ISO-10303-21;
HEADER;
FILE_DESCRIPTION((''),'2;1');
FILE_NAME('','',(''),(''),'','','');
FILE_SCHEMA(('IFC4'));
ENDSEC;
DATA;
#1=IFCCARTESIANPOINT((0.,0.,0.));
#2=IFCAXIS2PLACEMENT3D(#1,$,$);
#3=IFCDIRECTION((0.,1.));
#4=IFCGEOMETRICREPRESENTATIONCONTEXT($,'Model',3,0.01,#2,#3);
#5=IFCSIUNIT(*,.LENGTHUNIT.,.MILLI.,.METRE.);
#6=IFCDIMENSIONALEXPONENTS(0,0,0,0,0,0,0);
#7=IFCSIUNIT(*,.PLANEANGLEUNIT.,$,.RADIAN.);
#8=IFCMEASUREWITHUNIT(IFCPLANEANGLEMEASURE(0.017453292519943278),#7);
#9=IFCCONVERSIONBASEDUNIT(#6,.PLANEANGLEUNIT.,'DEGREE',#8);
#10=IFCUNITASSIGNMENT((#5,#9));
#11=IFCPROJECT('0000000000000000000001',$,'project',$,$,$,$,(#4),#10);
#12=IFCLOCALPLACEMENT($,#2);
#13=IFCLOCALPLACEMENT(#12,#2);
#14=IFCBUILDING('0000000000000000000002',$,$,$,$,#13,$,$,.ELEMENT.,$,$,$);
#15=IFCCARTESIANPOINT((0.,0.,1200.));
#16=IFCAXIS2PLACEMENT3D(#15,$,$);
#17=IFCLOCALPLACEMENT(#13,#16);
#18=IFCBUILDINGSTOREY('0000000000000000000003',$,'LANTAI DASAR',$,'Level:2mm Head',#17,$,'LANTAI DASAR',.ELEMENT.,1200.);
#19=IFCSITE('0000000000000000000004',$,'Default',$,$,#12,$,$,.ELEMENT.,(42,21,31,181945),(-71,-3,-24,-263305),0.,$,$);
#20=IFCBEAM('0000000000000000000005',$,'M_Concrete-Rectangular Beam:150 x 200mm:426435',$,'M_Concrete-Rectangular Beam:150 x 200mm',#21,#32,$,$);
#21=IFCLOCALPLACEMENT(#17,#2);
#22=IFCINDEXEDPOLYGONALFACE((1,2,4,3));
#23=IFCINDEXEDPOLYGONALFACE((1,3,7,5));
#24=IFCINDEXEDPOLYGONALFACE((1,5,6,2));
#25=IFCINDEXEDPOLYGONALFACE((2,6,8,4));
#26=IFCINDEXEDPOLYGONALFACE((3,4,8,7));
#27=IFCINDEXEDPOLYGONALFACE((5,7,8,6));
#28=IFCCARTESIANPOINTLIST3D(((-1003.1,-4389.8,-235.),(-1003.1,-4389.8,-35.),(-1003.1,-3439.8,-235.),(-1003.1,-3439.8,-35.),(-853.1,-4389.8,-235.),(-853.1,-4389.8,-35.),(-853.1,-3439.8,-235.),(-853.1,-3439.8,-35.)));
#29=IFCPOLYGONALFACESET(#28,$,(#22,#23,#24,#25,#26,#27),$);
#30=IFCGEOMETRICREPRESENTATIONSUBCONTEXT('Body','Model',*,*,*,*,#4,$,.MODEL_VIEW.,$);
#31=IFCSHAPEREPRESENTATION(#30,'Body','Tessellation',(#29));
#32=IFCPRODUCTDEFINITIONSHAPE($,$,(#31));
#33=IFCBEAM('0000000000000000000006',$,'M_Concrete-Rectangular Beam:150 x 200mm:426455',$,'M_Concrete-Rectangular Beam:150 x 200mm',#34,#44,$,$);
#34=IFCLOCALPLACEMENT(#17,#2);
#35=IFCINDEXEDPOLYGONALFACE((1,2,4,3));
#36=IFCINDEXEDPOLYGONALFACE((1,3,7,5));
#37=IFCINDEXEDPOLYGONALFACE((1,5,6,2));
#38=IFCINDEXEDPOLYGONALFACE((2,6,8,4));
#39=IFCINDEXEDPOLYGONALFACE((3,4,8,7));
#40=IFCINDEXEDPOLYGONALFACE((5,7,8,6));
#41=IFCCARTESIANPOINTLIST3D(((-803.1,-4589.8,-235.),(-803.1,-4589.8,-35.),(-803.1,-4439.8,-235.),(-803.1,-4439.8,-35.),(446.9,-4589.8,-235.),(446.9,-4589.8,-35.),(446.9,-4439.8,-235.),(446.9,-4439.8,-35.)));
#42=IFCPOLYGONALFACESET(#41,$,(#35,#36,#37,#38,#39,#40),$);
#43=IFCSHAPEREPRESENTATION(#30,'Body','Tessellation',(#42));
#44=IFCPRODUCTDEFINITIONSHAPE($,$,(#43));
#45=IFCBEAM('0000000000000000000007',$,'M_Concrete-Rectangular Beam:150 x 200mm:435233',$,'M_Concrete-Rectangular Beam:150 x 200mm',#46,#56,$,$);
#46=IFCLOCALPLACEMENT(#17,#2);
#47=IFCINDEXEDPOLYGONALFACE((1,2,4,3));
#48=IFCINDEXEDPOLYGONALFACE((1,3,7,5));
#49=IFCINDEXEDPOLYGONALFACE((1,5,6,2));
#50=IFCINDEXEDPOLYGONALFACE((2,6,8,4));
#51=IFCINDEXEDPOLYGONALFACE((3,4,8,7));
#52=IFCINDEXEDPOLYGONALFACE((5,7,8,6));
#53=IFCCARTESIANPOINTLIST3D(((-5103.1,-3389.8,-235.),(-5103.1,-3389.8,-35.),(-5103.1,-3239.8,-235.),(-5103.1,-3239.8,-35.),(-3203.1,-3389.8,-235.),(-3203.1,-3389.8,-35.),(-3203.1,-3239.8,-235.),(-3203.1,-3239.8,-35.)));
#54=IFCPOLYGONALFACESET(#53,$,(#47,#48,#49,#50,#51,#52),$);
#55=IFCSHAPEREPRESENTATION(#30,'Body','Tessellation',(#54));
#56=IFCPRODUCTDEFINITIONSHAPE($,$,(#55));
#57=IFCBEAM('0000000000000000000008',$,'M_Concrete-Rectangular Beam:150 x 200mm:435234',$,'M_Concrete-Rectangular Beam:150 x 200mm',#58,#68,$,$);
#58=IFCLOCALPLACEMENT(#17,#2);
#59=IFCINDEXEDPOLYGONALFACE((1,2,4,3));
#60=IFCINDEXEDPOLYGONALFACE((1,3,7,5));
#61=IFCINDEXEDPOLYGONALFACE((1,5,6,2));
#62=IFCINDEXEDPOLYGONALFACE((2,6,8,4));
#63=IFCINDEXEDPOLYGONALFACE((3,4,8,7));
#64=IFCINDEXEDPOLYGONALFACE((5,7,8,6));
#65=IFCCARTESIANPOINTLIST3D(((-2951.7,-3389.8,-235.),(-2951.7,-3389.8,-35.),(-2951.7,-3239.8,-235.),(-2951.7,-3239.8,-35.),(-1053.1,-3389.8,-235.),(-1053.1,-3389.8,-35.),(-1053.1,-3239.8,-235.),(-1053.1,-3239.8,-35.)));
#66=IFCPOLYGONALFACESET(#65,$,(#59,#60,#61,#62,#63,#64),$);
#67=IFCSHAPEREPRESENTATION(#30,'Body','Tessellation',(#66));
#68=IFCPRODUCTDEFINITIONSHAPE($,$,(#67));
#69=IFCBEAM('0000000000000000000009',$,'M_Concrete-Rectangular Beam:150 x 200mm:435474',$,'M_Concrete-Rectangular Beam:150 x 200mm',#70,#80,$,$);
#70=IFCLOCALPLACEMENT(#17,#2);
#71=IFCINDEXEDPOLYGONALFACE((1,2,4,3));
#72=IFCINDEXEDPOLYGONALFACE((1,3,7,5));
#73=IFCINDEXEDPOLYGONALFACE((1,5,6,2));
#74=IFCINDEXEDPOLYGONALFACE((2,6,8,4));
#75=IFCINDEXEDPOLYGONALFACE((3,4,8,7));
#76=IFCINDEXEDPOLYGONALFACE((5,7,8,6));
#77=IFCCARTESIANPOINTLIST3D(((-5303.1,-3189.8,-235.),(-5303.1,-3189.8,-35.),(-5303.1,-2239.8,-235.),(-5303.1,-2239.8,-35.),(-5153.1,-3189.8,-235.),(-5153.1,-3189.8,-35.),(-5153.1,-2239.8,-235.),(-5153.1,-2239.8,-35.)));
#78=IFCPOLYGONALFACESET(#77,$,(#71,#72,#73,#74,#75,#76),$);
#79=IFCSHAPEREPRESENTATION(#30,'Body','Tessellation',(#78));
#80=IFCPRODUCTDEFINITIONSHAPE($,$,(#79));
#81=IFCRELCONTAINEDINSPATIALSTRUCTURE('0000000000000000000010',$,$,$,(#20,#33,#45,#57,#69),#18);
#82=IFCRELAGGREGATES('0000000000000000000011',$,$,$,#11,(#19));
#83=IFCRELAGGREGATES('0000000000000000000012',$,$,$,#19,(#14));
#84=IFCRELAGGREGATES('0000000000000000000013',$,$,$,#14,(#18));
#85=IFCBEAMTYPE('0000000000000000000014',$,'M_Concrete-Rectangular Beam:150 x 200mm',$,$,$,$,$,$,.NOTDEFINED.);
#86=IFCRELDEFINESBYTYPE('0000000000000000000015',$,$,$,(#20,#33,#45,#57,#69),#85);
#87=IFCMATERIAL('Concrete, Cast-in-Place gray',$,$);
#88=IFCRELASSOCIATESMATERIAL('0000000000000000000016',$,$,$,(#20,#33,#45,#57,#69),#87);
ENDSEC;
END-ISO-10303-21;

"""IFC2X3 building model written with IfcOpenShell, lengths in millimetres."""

from ifc_helpers import new_model, entity, si_unit, converted_unit, direction, frame, frame_2d, origin, place, context, subcontext, project, spatial, rectangle, extrude, material, type_object, element, save


model = new_model("IFC2X3")

# Units and contexts
model_context = context("Model", 3, precision=0.01, world=origin(), true_north=direction((0.0, 1.0)))
body_context = subcontext(model_context, "Body", "Model", "MODEL_VIEW")
ifc_project = project(units=[si_unit("LENGTHUNIT", "METRE", prefix="MILLI"), converted_unit("PLANEANGLEUNIT", "DEGREE", entity("IfcPlaneAngleMeasure", 0.017453292519943278), si_unit("PLANEANGLEUNIT", "RADIAN"), dimensions=[0, 0, 0, 0, 0, 0, 0])], contexts=[model_context])

# Site, building, storey
site_placement = place(None, origin())
site = spatial("IfcSite", under=ifc_project, at=site_placement, Name="Default", CompositionType="ELEMENT", RefLatitude=(42, 21, 31, 181945), RefLongitude=(-71, -3, -24, -263305), RefElevation=0.0)
building_placement = place(site_placement, origin())
building = spatial("IfcBuilding", under=site, at=building_placement, CompositionType="ELEMENT")
storey_placement = place(building_placement, frame((0.0, 0.0, 1200.0)))
storey = spatial("IfcBuildingStorey", under=building, at=storey_placement, Name="LANTAI DASAR", ObjectType="Level:2mm Head", LongName="LANTAI DASAR", CompositionType="ELEMENT", Elevation=1200.0)

# Shared definitions
ifc_material = material(Name="Concrete, Cast-in-Place gray")

# Beams
beam_type = type_object("IfcBeamType", Name="M_Concrete-Rectangular Beam:150 x 200mm", PredefinedType="NOTDEFINED")
beam_1_placement = place(storey_placement, frame((-928.1, -3314.8, -35.0), z_axis=(0.0, 0.0, 1.0), x_axis=(0.0, -1.0, 0.0)))
element("IfcBeam", 1, at=beam_1_placement, inside=storey, type_object=beam_type, material=ifc_material, Name="M_Concrete-Rectangular Beam:150 x 200mm:426435", ObjectType="M_Concrete-Rectangular Beam:150 x 200mm", context=body_context, shape_type="SweptSolid", body=[
    extrude(rectangle(XDim=200.0, YDim=150.0, at=frame_2d((0.0, 0.0), x_axis=(1.0, 0.0))), frame((125.0, 0.0, -100.0), z_axis=(1.0, 0.0, 0.0), x_axis=(0.0, 0.0, -1.0)), (0.0, 0.0, 1.0), 950.0),
])
beam_2_placement = place(storey_placement, frame((-928.1, -4514.8, -35.0)))
element("IfcBeam", 2, at=beam_2_placement, inside=storey, type_object=beam_type, material=ifc_material, Name="M_Concrete-Rectangular Beam:150 x 200mm:426455", ObjectType="M_Concrete-Rectangular Beam:150 x 200mm", context=body_context, shape_type="SweptSolid", body=[
    extrude(rectangle(XDim=200.0, YDim=150.0, at=frame_2d((0.0, 0.0), x_axis=(1.0, 0.0))), frame((125.0, 0.0, -100.0), z_axis=(1.0, 0.0, 0.0), x_axis=(0.0, 0.0, -1.0)), (0.0, 0.0, 1.0), 1250.0),
])
beam_3_placement = place(storey_placement, frame((-5103.1, -3314.8, -35.0)))
element("IfcBeam", 3, at=beam_3_placement, inside=storey, type_object=beam_type, material=ifc_material, Name="M_Concrete-Rectangular Beam:150 x 200mm:435233", ObjectType="M_Concrete-Rectangular Beam:150 x 200mm", context=body_context, shape_type="SweptSolid", body=[
    extrude(rectangle(XDim=200.0, YDim=150.0, at=frame_2d((0.0, 0.0), x_axis=(1.0, 0.0))), frame((0.0, 0.0, -100.0), z_axis=(1.0, 0.0, 0.0), x_axis=(0.0, 0.0, -1.0)), (0.0, 0.0, 1.0), 1900.0),
])
beam_4_placement = place(storey_placement, frame((-3076.7, -3314.8, -35.0)))
element("IfcBeam", 4, at=beam_4_placement, inside=storey, type_object=beam_type, material=ifc_material, Name="M_Concrete-Rectangular Beam:150 x 200mm:435234", ObjectType="M_Concrete-Rectangular Beam:150 x 200mm", context=body_context, shape_type="SweptSolid", body=[
    extrude(rectangle(XDim=200.0, YDim=150.0, at=frame_2d((0.0, 0.0), x_axis=(1.0, 0.0))), frame((125.0, 0.0, -100.0), z_axis=(1.0, 0.0, 0.0), x_axis=(0.0, 0.0, -1.0)), (0.0, 0.0, 1.0), 1898.6),
])
beam_5_placement = place(storey_placement, frame((-5228.1, -2239.8, -35.0), z_axis=(0.0, 0.0, 1.0), x_axis=(0.0, -1.0, 0.0)))
element("IfcBeam", 5, at=beam_5_placement, inside=storey, type_object=beam_type, material=ifc_material, Name="M_Concrete-Rectangular Beam:150 x 200mm:435474", ObjectType="M_Concrete-Rectangular Beam:150 x 200mm", context=body_context, shape_type="SweptSolid", body=[
    extrude(rectangle(XDim=200.0, YDim=150.0, at=frame_2d((0.0, 0.0), x_axis=(1.0, 0.0))), frame((0.0, 0.0, -100.0), z_axis=(1.0, 0.0, 0.0), x_axis=(0.0, 0.0, -1.0)), (0.0, 0.0, 1.0), 950.0),
])

save(model, "model.ifc")
